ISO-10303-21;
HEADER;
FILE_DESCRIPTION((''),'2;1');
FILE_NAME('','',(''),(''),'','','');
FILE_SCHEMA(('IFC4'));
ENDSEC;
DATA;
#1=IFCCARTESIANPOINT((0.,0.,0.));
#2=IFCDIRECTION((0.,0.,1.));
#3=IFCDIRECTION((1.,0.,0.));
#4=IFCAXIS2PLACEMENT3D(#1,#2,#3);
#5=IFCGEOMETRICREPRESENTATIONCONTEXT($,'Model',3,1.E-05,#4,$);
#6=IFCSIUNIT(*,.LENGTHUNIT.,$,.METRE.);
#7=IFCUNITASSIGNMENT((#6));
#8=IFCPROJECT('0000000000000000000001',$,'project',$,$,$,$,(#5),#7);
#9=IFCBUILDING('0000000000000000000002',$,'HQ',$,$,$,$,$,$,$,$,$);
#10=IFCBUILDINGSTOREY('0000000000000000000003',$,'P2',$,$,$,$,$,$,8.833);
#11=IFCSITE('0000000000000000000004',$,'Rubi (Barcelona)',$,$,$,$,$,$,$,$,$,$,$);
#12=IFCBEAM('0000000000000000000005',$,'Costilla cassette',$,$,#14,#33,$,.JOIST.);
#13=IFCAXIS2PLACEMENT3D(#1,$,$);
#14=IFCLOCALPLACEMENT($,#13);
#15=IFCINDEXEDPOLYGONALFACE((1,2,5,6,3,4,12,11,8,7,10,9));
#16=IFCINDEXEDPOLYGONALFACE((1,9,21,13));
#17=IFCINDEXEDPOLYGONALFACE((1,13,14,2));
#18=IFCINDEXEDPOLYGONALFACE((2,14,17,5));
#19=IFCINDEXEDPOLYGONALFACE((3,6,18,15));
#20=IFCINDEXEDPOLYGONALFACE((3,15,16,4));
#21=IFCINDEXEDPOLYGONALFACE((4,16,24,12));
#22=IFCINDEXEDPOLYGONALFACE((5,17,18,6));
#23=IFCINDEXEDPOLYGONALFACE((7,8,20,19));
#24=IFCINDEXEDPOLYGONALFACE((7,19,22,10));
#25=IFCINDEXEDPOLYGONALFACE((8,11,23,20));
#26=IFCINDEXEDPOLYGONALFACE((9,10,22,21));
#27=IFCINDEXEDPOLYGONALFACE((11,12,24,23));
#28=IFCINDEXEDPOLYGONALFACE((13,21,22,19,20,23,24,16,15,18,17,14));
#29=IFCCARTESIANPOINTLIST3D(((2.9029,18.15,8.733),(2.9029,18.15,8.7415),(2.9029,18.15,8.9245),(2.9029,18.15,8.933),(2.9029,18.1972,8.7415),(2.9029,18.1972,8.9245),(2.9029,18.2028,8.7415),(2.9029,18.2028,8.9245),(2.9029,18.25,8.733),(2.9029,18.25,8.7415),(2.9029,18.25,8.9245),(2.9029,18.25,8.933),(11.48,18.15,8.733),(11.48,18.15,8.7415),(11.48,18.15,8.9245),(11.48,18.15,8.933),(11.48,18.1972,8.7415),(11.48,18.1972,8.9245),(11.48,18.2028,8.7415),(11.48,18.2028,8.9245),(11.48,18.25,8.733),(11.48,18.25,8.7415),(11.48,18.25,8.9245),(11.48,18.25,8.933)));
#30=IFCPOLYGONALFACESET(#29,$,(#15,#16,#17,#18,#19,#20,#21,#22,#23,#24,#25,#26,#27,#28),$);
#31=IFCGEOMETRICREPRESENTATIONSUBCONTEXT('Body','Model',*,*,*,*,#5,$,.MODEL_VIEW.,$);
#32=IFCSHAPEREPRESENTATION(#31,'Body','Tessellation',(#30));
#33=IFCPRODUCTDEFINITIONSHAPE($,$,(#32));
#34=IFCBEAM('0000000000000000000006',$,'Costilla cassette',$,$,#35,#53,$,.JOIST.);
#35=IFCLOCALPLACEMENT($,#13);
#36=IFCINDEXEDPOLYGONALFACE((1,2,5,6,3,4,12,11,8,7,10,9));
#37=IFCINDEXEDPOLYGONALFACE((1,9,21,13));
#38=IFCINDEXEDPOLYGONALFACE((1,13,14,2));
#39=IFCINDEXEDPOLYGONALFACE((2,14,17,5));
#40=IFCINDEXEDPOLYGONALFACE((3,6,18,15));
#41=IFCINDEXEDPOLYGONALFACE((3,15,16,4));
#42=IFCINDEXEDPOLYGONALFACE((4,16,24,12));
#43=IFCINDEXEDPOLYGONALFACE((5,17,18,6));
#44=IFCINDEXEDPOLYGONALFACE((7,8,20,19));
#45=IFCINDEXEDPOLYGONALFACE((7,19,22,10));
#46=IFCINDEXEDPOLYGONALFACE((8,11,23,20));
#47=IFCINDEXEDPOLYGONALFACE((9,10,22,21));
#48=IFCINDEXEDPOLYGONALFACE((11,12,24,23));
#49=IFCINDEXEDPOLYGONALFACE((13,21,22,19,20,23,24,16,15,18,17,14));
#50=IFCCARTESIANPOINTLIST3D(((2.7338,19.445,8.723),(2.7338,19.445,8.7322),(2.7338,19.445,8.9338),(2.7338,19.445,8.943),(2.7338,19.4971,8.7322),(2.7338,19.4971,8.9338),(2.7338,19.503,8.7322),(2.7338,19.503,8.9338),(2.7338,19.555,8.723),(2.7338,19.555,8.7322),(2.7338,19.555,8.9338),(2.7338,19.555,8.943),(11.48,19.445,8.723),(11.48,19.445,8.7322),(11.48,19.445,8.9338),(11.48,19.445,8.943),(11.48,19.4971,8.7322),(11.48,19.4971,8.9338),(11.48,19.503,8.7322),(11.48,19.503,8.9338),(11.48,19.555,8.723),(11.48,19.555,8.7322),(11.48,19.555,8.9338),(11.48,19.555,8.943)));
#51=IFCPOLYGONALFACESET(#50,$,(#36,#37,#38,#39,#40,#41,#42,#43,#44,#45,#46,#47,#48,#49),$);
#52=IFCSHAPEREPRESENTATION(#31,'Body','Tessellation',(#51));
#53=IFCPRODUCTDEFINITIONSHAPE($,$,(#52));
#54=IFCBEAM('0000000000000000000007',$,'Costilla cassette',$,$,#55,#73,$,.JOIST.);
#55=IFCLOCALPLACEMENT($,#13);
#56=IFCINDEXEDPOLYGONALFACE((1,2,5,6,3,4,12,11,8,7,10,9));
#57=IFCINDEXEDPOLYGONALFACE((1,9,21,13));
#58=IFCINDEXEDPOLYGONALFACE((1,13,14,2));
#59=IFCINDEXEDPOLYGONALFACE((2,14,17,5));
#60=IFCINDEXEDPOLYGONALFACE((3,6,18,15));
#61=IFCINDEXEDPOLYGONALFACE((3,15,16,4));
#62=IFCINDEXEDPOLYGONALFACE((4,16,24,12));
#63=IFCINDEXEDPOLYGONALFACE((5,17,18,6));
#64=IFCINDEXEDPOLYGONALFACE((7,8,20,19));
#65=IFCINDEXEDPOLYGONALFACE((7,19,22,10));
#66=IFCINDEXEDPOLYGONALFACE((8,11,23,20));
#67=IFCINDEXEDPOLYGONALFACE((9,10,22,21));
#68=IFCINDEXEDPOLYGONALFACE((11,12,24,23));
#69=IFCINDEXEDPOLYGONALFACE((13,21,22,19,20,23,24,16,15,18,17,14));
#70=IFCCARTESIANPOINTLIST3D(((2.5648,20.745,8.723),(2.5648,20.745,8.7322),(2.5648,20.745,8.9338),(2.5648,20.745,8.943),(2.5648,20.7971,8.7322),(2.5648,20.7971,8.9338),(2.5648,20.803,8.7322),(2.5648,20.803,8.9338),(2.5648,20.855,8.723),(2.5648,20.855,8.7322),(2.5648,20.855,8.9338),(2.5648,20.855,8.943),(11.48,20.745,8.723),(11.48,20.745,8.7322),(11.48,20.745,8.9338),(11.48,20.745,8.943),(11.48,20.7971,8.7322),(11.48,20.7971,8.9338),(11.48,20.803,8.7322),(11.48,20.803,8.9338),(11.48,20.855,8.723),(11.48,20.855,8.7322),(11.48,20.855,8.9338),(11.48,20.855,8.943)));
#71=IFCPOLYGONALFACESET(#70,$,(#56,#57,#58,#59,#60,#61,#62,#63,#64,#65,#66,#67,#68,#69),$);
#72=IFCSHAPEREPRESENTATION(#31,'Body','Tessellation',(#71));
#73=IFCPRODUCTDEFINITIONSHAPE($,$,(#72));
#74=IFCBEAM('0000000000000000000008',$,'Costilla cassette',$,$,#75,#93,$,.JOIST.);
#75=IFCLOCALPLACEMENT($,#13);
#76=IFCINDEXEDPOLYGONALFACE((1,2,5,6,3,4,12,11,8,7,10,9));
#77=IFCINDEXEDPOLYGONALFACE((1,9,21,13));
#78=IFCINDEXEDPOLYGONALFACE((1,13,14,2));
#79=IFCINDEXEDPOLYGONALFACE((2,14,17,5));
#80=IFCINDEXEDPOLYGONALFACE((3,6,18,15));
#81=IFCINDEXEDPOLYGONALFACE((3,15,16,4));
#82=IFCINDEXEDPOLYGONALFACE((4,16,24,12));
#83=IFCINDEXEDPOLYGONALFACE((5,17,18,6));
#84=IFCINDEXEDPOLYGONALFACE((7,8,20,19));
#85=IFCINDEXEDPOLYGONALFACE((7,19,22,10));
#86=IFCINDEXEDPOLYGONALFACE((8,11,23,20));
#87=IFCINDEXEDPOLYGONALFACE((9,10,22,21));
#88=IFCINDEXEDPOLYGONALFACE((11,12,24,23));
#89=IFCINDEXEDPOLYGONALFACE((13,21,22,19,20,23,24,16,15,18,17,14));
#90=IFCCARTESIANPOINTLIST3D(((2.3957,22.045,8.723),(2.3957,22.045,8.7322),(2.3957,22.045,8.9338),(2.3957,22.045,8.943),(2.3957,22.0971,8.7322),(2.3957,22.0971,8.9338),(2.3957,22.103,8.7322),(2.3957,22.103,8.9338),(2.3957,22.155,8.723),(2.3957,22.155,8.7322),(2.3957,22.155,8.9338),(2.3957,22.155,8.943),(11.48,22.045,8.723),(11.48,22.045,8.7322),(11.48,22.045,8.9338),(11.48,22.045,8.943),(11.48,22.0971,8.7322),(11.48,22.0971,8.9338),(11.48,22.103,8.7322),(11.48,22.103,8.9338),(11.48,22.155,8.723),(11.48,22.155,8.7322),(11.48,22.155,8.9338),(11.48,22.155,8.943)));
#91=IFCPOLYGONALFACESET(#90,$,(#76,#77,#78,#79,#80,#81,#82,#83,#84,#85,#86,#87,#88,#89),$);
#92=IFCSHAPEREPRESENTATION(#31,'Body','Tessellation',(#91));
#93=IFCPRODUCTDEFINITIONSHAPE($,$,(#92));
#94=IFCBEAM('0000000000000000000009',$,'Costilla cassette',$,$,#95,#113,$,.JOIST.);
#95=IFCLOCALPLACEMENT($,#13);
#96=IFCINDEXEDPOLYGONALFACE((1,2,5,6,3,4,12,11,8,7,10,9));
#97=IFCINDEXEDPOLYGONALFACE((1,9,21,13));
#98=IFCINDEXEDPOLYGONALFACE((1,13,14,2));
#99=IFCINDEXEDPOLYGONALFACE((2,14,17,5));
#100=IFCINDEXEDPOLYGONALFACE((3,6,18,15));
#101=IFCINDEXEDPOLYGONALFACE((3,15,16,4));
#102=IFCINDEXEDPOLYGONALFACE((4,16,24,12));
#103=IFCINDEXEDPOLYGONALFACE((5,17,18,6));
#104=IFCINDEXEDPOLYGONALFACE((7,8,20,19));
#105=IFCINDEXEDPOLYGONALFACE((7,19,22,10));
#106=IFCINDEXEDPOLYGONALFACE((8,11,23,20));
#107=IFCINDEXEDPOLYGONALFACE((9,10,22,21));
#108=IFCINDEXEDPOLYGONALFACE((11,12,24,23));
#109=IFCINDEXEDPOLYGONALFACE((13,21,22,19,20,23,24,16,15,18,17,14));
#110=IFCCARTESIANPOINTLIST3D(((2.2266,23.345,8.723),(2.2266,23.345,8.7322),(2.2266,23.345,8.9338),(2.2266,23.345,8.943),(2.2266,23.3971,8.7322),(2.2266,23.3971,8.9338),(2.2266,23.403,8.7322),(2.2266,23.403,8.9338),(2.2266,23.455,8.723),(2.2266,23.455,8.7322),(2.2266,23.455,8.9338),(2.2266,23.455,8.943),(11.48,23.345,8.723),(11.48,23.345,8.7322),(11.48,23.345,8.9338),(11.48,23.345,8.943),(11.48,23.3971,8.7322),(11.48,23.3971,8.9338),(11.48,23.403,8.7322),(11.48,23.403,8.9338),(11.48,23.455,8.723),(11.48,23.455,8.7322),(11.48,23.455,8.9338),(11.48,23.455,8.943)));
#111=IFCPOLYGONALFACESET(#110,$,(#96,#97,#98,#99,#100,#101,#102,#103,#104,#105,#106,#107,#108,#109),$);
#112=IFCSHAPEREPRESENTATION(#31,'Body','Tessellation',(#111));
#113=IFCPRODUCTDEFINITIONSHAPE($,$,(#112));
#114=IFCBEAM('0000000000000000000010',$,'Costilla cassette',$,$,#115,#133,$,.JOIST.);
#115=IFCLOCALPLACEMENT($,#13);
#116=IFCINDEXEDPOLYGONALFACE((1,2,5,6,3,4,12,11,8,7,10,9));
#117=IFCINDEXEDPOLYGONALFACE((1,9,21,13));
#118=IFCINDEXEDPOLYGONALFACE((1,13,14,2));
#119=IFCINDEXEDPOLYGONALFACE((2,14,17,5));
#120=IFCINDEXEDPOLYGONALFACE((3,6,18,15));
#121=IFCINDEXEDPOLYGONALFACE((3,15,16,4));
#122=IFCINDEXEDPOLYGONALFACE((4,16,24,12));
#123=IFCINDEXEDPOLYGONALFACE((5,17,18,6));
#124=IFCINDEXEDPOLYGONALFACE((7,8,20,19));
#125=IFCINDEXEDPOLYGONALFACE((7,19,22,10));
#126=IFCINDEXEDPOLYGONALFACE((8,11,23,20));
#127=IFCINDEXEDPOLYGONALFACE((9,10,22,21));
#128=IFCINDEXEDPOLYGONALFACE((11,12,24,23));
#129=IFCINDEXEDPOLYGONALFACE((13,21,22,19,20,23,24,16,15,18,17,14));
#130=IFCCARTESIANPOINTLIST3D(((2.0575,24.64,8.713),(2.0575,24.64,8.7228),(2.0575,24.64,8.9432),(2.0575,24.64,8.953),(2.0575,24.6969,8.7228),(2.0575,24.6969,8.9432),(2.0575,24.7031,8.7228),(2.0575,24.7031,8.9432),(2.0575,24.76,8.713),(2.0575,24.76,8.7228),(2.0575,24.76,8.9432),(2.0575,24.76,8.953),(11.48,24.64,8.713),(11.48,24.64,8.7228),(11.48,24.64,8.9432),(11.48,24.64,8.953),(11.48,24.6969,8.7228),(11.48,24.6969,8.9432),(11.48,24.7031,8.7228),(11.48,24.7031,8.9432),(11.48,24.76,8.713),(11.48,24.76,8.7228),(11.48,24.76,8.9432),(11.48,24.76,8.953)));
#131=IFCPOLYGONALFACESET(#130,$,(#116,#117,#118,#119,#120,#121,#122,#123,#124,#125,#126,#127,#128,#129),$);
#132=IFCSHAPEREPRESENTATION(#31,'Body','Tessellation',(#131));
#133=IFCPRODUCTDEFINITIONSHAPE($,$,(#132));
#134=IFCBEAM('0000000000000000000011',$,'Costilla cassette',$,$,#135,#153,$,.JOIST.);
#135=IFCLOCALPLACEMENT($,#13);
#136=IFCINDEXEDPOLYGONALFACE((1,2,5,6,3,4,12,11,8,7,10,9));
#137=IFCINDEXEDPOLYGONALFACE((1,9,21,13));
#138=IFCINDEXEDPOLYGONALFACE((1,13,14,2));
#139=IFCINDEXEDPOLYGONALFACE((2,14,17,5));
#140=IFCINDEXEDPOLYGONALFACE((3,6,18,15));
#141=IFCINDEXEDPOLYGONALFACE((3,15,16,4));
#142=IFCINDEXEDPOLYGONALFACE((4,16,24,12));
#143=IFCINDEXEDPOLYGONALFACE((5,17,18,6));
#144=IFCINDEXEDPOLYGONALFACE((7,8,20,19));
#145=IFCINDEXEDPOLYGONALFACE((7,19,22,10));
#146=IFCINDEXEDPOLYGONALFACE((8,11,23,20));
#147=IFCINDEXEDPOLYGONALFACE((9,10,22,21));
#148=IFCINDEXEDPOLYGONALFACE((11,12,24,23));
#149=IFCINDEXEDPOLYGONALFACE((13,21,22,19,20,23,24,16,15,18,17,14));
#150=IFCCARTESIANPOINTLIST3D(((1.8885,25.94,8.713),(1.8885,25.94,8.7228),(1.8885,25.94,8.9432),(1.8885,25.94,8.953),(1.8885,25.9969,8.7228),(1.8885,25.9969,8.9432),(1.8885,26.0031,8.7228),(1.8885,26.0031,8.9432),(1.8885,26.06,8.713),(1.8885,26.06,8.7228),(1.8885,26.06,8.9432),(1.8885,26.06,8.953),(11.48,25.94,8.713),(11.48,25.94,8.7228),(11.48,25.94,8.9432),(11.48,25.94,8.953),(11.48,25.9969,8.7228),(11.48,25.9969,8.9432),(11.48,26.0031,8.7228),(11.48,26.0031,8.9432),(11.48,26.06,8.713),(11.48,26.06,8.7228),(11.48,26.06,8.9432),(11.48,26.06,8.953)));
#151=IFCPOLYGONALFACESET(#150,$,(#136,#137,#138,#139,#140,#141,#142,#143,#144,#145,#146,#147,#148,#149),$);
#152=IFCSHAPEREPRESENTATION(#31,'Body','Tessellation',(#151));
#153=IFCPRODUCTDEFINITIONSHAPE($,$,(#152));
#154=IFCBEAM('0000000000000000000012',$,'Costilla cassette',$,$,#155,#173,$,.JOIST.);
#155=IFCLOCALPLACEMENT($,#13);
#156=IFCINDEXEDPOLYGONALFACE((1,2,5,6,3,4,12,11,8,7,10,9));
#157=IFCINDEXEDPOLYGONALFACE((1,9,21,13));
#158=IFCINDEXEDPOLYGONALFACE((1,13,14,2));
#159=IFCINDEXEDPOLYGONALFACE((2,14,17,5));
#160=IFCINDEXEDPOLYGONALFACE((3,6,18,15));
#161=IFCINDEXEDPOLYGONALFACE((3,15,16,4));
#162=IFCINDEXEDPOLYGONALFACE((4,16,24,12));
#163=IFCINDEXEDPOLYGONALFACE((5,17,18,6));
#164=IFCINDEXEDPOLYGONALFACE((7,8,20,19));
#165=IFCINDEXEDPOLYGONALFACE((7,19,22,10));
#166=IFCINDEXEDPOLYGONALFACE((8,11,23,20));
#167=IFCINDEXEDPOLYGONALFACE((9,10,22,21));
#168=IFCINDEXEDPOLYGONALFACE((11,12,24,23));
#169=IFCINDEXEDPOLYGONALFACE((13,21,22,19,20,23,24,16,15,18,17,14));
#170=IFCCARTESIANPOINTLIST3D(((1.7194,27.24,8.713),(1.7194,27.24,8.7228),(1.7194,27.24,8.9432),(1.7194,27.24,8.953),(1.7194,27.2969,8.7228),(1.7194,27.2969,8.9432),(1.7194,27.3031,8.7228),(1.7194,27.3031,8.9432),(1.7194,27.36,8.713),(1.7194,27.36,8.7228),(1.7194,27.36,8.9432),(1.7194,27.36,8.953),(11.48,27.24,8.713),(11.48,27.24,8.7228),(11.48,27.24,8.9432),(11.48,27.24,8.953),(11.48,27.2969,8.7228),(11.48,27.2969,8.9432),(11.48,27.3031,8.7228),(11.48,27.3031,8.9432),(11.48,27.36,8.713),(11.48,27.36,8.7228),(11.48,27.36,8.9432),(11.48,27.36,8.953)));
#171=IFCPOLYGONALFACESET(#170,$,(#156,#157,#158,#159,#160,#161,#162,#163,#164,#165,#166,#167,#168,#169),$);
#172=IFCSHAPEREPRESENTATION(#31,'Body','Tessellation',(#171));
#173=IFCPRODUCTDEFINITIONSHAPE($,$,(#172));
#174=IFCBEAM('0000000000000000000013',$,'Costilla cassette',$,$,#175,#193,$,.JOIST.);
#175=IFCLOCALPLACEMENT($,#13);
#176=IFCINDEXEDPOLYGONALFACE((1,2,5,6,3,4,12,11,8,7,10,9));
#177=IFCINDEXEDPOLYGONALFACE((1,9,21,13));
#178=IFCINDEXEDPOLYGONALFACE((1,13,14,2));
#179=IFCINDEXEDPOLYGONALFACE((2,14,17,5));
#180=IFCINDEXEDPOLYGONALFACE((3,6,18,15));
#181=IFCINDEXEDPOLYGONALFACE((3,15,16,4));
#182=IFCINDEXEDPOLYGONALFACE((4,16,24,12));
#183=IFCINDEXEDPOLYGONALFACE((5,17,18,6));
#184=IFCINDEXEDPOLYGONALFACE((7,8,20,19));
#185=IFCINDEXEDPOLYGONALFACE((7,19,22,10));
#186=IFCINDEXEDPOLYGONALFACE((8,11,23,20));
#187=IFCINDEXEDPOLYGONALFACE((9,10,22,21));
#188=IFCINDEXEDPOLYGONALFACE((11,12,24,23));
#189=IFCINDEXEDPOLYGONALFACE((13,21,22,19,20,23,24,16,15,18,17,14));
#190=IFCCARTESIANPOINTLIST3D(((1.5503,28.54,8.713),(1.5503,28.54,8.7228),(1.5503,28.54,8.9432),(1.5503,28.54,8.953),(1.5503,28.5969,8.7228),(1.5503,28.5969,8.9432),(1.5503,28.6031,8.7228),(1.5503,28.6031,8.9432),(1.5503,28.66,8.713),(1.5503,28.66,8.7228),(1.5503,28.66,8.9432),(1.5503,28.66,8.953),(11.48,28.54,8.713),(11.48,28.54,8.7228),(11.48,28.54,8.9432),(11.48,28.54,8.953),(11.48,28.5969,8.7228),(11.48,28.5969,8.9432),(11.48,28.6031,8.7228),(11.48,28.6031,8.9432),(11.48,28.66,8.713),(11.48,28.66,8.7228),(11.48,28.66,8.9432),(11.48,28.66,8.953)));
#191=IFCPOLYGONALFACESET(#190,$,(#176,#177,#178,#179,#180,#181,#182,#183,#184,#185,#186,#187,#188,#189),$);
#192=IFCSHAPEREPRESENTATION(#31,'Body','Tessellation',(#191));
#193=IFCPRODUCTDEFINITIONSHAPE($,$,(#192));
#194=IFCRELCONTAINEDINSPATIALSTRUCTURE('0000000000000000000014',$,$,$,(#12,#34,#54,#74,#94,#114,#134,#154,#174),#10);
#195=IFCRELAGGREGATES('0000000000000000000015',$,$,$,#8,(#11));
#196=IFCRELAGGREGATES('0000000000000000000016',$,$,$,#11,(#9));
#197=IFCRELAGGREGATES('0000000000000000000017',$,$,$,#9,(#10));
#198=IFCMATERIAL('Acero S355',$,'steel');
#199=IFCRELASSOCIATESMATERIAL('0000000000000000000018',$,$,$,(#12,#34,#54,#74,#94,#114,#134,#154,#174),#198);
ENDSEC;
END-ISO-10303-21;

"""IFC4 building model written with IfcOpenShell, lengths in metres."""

from ifc_helpers import new_model, si_unit, frame, origin_with_axes, place, context, subcontext, project, spatial, i_section, extrude, material, element, save


model = new_model("IFC4")

# Units and contexts
model_context = context("Model", 3, precision=1e-05, world=origin_with_axes())
body_context = subcontext(model_context, "Body", "Model", "MODEL_VIEW")
ifc_project = project(units=[si_unit("LENGTHUNIT", "METRE")], contexts=[model_context])

# Site, building, storey
site = spatial("IfcSite", under=ifc_project, Name="Rubi (Barcelona)")
building = spatial("IfcBuilding", under=site, Name="HQ")
storey = spatial("IfcBuildingStorey", under=building, Name="P2", Elevation=8.833)

# Beams
ifc_material_1 = material(Name="Acero S355", Category="steel")
beam_1_placement = place(None, origin_with_axes())
element("IfcBeam", 1, at=beam_1_placement, inside=storey, material=ifc_material_1, Name="Costilla cassette", PredefinedType="JOIST", context=body_context, shape_type="SweptSolid", body=[
    extrude(i_section(OverallWidth=0.1, OverallDepth=0.2, WebThickness=0.0056, FlangeThickness=0.0085), frame((2.9029, 18.2, 8.833), z_axis=(1.0, 0.0, 0.0), x_axis=(0.0, 1.0, 0.0)), (0.0, 0.0, 1.0), 8.5771),
])
beam_2_placement = place(None, origin_with_axes())
element("IfcBeam", 2, at=beam_2_placement, inside=storey, material=ifc_material_1, Name="Costilla cassette", PredefinedType="JOIST", context=body_context, shape_type="SweptSolid", body=[
    extrude(i_section(OverallWidth=0.11, OverallDepth=0.22, WebThickness=0.0059, FlangeThickness=0.0092), frame((2.7338, 19.5, 8.833), z_axis=(1.0, 0.0, 0.0), x_axis=(0.0, 1.0, 0.0)), (0.0, 0.0, 1.0), 8.7462),
])
beam_3_placement = place(None, origin_with_axes())
element("IfcBeam", 3, at=beam_3_placement, inside=storey, material=ifc_material_1, Name="Costilla cassette", PredefinedType="JOIST", context=body_context, shape_type="SweptSolid", body=[
    extrude(i_section(OverallWidth=0.11, OverallDepth=0.22, WebThickness=0.0059, FlangeThickness=0.0092), frame((2.5648, 20.8, 8.833), z_axis=(1.0, 0.0, 0.0), x_axis=(0.0, 1.0, 0.0)), (0.0, 0.0, 1.0), 8.9152),
])
beam_4_placement = place(None, origin_with_axes())
element("IfcBeam", 4, at=beam_4_placement, inside=storey, material=ifc_material_1, Name="Costilla cassette", PredefinedType="JOIST", context=body_context, shape_type="SweptSolid", body=[
    extrude(i_section(OverallWidth=0.11, OverallDepth=0.22, WebThickness=0.0059, FlangeThickness=0.0092), frame((2.3957, 22.1, 8.833), z_axis=(1.0, 0.0, 0.0), x_axis=(0.0, 1.0, 0.0)), (0.0, 0.0, 1.0), 9.0843),
])
beam_5_placement = place(None, origin_with_axes())
element("IfcBeam", 5, at=beam_5_placement, inside=storey, material=ifc_material_1, Name="Costilla cassette", PredefinedType="JOIST", context=body_context, shape_type="SweptSolid", body=[
    extrude(i_section(OverallWidth=0.11, OverallDepth=0.22, WebThickness=0.0059, FlangeThickness=0.0092), frame((2.2266, 23.4, 8.833), z_axis=(1.0, 0.0, 0.0), x_axis=(0.0, 1.0, 0.0)), (0.0, 0.0, 1.0), 9.2534),
])
beam_6_placement = place(None, origin_with_axes())
element("IfcBeam", 6, at=beam_6_placement, inside=storey, material=ifc_material_1, Name="Costilla cassette", PredefinedType="JOIST", context=body_context, shape_type="SweptSolid", body=[
    extrude(i_section(OverallWidth=0.12, OverallDepth=0.24, WebThickness=0.0062, FlangeThickness=0.0098), frame((2.0575, 24.7, 8.833), z_axis=(1.0, 0.0, 0.0), x_axis=(0.0, 1.0, 0.0)), (0.0, 0.0, 1.0), 9.4225),
])
beam_7_placement = place(None, origin_with_axes())
element("IfcBeam", 7, at=beam_7_placement, inside=storey, material=ifc_material_1, Name="Costilla cassette", PredefinedType="JOIST", context=body_context, shape_type="SweptSolid", body=[
    extrude(i_section(OverallWidth=0.12, OverallDepth=0.24, WebThickness=0.0062, FlangeThickness=0.0098), frame((1.8885, 26.0, 8.833), z_axis=(1.0, 0.0, 0.0), x_axis=(0.0, 1.0, 0.0)), (0.0, 0.0, 1.0), 9.5915),
])
beam_8_placement = place(None, origin_with_axes())
element("IfcBeam", 8, at=beam_8_placement, inside=storey, material=ifc_material_1, Name="Costilla cassette", PredefinedType="JOIST", context=body_context, shape_type="SweptSolid", body=[
    extrude(i_section(OverallWidth=0.12, OverallDepth=0.24, WebThickness=0.0062, FlangeThickness=0.0098), frame((1.7194, 27.3, 8.833), z_axis=(1.0, 0.0, 0.0), x_axis=(0.0, 1.0, 0.0)), (0.0, 0.0, 1.0), 9.7606),
])
beam_9_placement = place(None, origin_with_axes())
element("IfcBeam", 9, at=beam_9_placement, inside=storey, material=ifc_material_1, Name="Costilla cassette", PredefinedType="JOIST", context=body_context, shape_type="SweptSolid", body=[
    extrude(i_section(OverallWidth=0.12, OverallDepth=0.24, WebThickness=0.0062, FlangeThickness=0.0098), frame((1.5503, 28.6, 8.833), z_axis=(1.0, 0.0, 0.0), x_axis=(0.0, 1.0, 0.0)), (0.0, 0.0, 1.0), 9.9297),
])

save(model, "model.ifc")
